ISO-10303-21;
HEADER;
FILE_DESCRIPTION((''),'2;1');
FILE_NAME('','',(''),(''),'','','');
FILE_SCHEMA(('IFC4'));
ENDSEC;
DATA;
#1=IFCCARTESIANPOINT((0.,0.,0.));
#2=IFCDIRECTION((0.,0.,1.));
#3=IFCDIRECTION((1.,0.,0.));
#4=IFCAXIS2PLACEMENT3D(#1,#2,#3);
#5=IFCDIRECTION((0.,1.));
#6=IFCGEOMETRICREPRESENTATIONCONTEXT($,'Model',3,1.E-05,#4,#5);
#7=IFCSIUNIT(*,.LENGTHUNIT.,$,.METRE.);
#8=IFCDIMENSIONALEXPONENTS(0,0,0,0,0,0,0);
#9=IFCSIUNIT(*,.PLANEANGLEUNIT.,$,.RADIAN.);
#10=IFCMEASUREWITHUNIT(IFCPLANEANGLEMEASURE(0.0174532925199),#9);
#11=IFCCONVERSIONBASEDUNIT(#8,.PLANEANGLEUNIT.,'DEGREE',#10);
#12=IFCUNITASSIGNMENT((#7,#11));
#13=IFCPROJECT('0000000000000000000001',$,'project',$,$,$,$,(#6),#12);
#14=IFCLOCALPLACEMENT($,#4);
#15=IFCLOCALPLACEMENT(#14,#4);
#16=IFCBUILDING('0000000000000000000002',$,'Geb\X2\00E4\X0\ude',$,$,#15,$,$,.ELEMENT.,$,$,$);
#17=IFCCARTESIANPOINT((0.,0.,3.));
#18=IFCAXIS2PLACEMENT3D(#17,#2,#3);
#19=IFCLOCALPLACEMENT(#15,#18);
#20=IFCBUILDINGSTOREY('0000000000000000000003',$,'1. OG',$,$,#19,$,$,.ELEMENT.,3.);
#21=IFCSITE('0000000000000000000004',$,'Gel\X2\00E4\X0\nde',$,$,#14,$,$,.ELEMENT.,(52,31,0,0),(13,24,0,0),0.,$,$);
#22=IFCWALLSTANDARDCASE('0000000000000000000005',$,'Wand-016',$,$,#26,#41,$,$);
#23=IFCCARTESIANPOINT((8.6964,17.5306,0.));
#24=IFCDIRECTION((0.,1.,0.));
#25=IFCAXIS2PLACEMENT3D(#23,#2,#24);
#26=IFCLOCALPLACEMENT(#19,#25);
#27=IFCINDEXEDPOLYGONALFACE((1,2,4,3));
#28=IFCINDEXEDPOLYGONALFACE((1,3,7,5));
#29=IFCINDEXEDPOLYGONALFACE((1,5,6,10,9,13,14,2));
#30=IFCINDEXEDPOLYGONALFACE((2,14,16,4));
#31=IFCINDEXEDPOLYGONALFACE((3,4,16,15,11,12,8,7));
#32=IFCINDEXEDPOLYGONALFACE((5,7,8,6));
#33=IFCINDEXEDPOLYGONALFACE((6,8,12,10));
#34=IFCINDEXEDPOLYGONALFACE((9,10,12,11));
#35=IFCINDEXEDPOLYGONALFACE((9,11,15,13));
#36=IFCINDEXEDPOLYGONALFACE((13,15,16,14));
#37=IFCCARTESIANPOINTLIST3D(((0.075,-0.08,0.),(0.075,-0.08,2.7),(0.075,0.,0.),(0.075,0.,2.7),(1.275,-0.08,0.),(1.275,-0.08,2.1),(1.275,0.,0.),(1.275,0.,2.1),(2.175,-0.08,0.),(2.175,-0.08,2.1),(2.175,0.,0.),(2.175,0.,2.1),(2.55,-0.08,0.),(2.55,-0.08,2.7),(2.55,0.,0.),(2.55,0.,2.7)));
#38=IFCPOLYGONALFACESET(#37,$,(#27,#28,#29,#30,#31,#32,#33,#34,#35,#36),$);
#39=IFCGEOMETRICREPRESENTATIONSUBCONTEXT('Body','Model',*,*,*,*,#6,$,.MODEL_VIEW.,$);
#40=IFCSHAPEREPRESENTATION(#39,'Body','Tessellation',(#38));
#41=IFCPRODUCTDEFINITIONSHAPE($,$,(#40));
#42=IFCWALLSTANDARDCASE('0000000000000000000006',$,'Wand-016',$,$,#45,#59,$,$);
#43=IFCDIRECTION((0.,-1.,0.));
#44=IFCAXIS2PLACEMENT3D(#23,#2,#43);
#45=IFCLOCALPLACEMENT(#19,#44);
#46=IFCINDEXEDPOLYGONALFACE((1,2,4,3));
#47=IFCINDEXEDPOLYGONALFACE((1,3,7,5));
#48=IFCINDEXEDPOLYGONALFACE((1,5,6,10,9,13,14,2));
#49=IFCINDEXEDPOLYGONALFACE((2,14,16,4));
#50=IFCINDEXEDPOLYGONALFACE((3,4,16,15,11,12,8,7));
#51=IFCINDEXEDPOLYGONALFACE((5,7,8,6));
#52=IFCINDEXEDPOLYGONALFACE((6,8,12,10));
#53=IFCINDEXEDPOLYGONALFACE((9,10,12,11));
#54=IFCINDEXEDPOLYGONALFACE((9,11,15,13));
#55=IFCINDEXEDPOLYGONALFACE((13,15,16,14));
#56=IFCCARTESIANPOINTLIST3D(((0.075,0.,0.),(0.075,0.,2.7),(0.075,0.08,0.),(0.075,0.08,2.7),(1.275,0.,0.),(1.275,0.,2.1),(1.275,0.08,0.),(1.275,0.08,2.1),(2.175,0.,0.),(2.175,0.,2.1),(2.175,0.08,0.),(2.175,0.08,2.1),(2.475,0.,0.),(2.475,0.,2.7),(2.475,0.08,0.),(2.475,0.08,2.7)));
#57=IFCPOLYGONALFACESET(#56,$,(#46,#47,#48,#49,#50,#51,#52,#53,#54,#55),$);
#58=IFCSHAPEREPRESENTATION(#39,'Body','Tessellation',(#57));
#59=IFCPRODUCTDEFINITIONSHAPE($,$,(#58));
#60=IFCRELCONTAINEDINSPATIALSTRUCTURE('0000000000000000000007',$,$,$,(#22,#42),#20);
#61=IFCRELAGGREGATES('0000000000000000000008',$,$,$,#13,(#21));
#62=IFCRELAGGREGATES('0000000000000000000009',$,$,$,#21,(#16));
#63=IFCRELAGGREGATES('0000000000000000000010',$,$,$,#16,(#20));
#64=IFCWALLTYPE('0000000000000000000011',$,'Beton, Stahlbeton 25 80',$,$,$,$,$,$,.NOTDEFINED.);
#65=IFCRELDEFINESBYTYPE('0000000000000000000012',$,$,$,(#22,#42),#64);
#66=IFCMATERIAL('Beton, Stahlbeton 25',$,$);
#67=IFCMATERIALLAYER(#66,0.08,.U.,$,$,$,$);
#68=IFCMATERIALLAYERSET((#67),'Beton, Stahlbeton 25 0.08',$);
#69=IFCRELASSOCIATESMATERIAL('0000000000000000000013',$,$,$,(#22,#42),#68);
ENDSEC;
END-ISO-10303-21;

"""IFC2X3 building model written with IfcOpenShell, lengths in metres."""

from ifc_helpers import new_model, entity, si_unit, converted_unit, direction, frame, origin_with_axes, origin_2d_with_axis, place, context, subcontext, project, spatial, polyline, rectangle, outline, extrude, material, layer, layer_set, layer_usage, type_object, element, save


model = new_model("IFC2X3")

# Units and contexts
model_context = context("Model", 3, precision=1e-05, world=origin_with_axes(), true_north=direction((0.0, 1.0)))
body_context = subcontext(model_context, "Body", "Model", "MODEL_VIEW")
ifc_project = project(units=[si_unit("LENGTHUNIT", "METRE"), converted_unit("PLANEANGLEUNIT", "DEGREE", entity("IfcPlaneAngleMeasure", 0.0174532925199), si_unit("PLANEANGLEUNIT", "RADIAN"), dimensions=[0, 0, 0, 0, 0, 0, 0])], contexts=[model_context])

# Site, building, storey
site_placement = place(None, origin_with_axes())
site = spatial("IfcSite", under=ifc_project, at=site_placement, Name="Gelände", CompositionType="ELEMENT", RefLatitude=(52, 31, 0, 0), RefLongitude=(13, 24, 0, 0), RefElevation=0.0)
building_placement = place(site_placement, origin_with_axes())
building = spatial("IfcBuilding", under=site, at=building_placement, Name="Gebäude", CompositionType="ELEMENT")
storey_placement = place(building_placement, frame((0.0, 0.0, 3.0), z_axis=(0.0, 0.0, 1.0), x_axis=(1.0, 0.0, 0.0)))
storey = spatial("IfcBuildingStorey", under=building, at=storey_placement, Name="1. OG", CompositionType="ELEMENT", Elevation=3.0)

# Shared definitions
ifc_material = material(Name="Beton, Stahlbeton 25")

# Walls, openings
ifc_layer_1 = layer(ifc_material, 0.08, ventilated="UNKNOWN")
ifc_layer_set_1 = layer_set([ifc_layer_1], Name="Beton, Stahlbeton 25 0.08")
ifc_layer_usage_1 = layer_usage(ifc_layer_set_1, "AXIS2", "NEGATIVE", 0.0)
wall_type_1 = type_object("IfcWallType", Name="Beton, Stahlbeton 25 80", PredefinedType="NOTDEFINED")
wall_1_placement = place(storey_placement, frame((8.6964, 17.5306, 0.0), z_axis=(0.0, 0.0, 1.0), x_axis=(0.0, 1.0, 0.0)))
wall_1 = element("IfcWallStandardCase", 1, at=wall_1_placement, inside=storey, type_object=wall_type_1, material=ifc_layer_usage_1, Name="Wand-016", context=body_context, shape_type="SweptSolid", body=[
    extrude(outline(polyline([(0.075, -0.08), (2.55, -0.08), (2.55, 0.0), (0.075, 0.0), (0.075, -0.08)])), origin_with_axes(), (0.0, 0.0, 1.0), 2.7),
])
opening_1_placement = place(wall_1_placement, frame((1.725, 0.0, 0.0), z_axis=(0.0, 0.0, 1.0), x_axis=(1.0, 0.0, 0.0)))
element("IfcOpeningElement", 2, at=opening_1_placement, cuts=wall_1, context=body_context, shape_type="SweptSolid", body=[
    extrude(rectangle(XDim=0.9, YDim=2.1, at=origin_2d_with_axis()), frame((0.0, -0.16, 1.05), z_axis=(0.0, 1.0, 0.0), x_axis=(1.0, 0.0, 0.0)), (0.0, 0.0, 1.0), 0.08),
    extrude(rectangle(XDim=0.9, YDim=2.1, at=origin_2d_with_axis()), frame((0.0, 0.0, 1.05), z_axis=(0.0, -1.0, 0.0), x_axis=(1.0, 0.0, 0.0)), (0.0, 0.0, 1.0), 0.08),
])
ifc_layer_usage_2 = layer_usage(ifc_layer_set_1, "AXIS2", "POSITIVE", 0.0)
wall_2_placement = place(storey_placement, frame((8.6964, 17.5306, 0.0), z_axis=(0.0, 0.0, 1.0), x_axis=(0.0, -1.0, 0.0)))
wall_2 = element("IfcWallStandardCase", 3, at=wall_2_placement, inside=storey, type_object=wall_type_1, material=ifc_layer_usage_2, Name="Wand-016", context=body_context, shape_type="SweptSolid", body=[
    extrude(outline(polyline([(0.075, 0.0), (2.475, 0.0), (2.475, 0.08), (0.075, 0.08), (0.075, 0.0)])), origin_with_axes(), (0.0, 0.0, 1.0), 2.7),
])
opening_2_placement = place(wall_2_placement, frame((1.725, 0.0, 0.0), z_axis=(0.0, 0.0, 1.0), x_axis=(1.0, 0.0, 0.0)))
element("IfcOpeningElement", 4, at=opening_2_placement, cuts=wall_2, context=body_context, shape_type="SweptSolid", body=[
    extrude(rectangle(XDim=0.9, YDim=2.1, at=origin_2d_with_axis()), frame((0.0, 0.16, 1.05), z_axis=(0.0, -1.0, 0.0), x_axis=(1.0, 0.0, 0.0)), (0.0, 0.0, 1.0), 0.08),
    extrude(rectangle(XDim=0.9, YDim=2.1, at=origin_2d_with_axis()), frame((0.0, 0.0, 1.05), z_axis=(0.0, 1.0, 0.0), x_axis=(1.0, 0.0, 0.0)), (0.0, 0.0, 1.0), 0.08),
])

save(model, "model.ifc")
